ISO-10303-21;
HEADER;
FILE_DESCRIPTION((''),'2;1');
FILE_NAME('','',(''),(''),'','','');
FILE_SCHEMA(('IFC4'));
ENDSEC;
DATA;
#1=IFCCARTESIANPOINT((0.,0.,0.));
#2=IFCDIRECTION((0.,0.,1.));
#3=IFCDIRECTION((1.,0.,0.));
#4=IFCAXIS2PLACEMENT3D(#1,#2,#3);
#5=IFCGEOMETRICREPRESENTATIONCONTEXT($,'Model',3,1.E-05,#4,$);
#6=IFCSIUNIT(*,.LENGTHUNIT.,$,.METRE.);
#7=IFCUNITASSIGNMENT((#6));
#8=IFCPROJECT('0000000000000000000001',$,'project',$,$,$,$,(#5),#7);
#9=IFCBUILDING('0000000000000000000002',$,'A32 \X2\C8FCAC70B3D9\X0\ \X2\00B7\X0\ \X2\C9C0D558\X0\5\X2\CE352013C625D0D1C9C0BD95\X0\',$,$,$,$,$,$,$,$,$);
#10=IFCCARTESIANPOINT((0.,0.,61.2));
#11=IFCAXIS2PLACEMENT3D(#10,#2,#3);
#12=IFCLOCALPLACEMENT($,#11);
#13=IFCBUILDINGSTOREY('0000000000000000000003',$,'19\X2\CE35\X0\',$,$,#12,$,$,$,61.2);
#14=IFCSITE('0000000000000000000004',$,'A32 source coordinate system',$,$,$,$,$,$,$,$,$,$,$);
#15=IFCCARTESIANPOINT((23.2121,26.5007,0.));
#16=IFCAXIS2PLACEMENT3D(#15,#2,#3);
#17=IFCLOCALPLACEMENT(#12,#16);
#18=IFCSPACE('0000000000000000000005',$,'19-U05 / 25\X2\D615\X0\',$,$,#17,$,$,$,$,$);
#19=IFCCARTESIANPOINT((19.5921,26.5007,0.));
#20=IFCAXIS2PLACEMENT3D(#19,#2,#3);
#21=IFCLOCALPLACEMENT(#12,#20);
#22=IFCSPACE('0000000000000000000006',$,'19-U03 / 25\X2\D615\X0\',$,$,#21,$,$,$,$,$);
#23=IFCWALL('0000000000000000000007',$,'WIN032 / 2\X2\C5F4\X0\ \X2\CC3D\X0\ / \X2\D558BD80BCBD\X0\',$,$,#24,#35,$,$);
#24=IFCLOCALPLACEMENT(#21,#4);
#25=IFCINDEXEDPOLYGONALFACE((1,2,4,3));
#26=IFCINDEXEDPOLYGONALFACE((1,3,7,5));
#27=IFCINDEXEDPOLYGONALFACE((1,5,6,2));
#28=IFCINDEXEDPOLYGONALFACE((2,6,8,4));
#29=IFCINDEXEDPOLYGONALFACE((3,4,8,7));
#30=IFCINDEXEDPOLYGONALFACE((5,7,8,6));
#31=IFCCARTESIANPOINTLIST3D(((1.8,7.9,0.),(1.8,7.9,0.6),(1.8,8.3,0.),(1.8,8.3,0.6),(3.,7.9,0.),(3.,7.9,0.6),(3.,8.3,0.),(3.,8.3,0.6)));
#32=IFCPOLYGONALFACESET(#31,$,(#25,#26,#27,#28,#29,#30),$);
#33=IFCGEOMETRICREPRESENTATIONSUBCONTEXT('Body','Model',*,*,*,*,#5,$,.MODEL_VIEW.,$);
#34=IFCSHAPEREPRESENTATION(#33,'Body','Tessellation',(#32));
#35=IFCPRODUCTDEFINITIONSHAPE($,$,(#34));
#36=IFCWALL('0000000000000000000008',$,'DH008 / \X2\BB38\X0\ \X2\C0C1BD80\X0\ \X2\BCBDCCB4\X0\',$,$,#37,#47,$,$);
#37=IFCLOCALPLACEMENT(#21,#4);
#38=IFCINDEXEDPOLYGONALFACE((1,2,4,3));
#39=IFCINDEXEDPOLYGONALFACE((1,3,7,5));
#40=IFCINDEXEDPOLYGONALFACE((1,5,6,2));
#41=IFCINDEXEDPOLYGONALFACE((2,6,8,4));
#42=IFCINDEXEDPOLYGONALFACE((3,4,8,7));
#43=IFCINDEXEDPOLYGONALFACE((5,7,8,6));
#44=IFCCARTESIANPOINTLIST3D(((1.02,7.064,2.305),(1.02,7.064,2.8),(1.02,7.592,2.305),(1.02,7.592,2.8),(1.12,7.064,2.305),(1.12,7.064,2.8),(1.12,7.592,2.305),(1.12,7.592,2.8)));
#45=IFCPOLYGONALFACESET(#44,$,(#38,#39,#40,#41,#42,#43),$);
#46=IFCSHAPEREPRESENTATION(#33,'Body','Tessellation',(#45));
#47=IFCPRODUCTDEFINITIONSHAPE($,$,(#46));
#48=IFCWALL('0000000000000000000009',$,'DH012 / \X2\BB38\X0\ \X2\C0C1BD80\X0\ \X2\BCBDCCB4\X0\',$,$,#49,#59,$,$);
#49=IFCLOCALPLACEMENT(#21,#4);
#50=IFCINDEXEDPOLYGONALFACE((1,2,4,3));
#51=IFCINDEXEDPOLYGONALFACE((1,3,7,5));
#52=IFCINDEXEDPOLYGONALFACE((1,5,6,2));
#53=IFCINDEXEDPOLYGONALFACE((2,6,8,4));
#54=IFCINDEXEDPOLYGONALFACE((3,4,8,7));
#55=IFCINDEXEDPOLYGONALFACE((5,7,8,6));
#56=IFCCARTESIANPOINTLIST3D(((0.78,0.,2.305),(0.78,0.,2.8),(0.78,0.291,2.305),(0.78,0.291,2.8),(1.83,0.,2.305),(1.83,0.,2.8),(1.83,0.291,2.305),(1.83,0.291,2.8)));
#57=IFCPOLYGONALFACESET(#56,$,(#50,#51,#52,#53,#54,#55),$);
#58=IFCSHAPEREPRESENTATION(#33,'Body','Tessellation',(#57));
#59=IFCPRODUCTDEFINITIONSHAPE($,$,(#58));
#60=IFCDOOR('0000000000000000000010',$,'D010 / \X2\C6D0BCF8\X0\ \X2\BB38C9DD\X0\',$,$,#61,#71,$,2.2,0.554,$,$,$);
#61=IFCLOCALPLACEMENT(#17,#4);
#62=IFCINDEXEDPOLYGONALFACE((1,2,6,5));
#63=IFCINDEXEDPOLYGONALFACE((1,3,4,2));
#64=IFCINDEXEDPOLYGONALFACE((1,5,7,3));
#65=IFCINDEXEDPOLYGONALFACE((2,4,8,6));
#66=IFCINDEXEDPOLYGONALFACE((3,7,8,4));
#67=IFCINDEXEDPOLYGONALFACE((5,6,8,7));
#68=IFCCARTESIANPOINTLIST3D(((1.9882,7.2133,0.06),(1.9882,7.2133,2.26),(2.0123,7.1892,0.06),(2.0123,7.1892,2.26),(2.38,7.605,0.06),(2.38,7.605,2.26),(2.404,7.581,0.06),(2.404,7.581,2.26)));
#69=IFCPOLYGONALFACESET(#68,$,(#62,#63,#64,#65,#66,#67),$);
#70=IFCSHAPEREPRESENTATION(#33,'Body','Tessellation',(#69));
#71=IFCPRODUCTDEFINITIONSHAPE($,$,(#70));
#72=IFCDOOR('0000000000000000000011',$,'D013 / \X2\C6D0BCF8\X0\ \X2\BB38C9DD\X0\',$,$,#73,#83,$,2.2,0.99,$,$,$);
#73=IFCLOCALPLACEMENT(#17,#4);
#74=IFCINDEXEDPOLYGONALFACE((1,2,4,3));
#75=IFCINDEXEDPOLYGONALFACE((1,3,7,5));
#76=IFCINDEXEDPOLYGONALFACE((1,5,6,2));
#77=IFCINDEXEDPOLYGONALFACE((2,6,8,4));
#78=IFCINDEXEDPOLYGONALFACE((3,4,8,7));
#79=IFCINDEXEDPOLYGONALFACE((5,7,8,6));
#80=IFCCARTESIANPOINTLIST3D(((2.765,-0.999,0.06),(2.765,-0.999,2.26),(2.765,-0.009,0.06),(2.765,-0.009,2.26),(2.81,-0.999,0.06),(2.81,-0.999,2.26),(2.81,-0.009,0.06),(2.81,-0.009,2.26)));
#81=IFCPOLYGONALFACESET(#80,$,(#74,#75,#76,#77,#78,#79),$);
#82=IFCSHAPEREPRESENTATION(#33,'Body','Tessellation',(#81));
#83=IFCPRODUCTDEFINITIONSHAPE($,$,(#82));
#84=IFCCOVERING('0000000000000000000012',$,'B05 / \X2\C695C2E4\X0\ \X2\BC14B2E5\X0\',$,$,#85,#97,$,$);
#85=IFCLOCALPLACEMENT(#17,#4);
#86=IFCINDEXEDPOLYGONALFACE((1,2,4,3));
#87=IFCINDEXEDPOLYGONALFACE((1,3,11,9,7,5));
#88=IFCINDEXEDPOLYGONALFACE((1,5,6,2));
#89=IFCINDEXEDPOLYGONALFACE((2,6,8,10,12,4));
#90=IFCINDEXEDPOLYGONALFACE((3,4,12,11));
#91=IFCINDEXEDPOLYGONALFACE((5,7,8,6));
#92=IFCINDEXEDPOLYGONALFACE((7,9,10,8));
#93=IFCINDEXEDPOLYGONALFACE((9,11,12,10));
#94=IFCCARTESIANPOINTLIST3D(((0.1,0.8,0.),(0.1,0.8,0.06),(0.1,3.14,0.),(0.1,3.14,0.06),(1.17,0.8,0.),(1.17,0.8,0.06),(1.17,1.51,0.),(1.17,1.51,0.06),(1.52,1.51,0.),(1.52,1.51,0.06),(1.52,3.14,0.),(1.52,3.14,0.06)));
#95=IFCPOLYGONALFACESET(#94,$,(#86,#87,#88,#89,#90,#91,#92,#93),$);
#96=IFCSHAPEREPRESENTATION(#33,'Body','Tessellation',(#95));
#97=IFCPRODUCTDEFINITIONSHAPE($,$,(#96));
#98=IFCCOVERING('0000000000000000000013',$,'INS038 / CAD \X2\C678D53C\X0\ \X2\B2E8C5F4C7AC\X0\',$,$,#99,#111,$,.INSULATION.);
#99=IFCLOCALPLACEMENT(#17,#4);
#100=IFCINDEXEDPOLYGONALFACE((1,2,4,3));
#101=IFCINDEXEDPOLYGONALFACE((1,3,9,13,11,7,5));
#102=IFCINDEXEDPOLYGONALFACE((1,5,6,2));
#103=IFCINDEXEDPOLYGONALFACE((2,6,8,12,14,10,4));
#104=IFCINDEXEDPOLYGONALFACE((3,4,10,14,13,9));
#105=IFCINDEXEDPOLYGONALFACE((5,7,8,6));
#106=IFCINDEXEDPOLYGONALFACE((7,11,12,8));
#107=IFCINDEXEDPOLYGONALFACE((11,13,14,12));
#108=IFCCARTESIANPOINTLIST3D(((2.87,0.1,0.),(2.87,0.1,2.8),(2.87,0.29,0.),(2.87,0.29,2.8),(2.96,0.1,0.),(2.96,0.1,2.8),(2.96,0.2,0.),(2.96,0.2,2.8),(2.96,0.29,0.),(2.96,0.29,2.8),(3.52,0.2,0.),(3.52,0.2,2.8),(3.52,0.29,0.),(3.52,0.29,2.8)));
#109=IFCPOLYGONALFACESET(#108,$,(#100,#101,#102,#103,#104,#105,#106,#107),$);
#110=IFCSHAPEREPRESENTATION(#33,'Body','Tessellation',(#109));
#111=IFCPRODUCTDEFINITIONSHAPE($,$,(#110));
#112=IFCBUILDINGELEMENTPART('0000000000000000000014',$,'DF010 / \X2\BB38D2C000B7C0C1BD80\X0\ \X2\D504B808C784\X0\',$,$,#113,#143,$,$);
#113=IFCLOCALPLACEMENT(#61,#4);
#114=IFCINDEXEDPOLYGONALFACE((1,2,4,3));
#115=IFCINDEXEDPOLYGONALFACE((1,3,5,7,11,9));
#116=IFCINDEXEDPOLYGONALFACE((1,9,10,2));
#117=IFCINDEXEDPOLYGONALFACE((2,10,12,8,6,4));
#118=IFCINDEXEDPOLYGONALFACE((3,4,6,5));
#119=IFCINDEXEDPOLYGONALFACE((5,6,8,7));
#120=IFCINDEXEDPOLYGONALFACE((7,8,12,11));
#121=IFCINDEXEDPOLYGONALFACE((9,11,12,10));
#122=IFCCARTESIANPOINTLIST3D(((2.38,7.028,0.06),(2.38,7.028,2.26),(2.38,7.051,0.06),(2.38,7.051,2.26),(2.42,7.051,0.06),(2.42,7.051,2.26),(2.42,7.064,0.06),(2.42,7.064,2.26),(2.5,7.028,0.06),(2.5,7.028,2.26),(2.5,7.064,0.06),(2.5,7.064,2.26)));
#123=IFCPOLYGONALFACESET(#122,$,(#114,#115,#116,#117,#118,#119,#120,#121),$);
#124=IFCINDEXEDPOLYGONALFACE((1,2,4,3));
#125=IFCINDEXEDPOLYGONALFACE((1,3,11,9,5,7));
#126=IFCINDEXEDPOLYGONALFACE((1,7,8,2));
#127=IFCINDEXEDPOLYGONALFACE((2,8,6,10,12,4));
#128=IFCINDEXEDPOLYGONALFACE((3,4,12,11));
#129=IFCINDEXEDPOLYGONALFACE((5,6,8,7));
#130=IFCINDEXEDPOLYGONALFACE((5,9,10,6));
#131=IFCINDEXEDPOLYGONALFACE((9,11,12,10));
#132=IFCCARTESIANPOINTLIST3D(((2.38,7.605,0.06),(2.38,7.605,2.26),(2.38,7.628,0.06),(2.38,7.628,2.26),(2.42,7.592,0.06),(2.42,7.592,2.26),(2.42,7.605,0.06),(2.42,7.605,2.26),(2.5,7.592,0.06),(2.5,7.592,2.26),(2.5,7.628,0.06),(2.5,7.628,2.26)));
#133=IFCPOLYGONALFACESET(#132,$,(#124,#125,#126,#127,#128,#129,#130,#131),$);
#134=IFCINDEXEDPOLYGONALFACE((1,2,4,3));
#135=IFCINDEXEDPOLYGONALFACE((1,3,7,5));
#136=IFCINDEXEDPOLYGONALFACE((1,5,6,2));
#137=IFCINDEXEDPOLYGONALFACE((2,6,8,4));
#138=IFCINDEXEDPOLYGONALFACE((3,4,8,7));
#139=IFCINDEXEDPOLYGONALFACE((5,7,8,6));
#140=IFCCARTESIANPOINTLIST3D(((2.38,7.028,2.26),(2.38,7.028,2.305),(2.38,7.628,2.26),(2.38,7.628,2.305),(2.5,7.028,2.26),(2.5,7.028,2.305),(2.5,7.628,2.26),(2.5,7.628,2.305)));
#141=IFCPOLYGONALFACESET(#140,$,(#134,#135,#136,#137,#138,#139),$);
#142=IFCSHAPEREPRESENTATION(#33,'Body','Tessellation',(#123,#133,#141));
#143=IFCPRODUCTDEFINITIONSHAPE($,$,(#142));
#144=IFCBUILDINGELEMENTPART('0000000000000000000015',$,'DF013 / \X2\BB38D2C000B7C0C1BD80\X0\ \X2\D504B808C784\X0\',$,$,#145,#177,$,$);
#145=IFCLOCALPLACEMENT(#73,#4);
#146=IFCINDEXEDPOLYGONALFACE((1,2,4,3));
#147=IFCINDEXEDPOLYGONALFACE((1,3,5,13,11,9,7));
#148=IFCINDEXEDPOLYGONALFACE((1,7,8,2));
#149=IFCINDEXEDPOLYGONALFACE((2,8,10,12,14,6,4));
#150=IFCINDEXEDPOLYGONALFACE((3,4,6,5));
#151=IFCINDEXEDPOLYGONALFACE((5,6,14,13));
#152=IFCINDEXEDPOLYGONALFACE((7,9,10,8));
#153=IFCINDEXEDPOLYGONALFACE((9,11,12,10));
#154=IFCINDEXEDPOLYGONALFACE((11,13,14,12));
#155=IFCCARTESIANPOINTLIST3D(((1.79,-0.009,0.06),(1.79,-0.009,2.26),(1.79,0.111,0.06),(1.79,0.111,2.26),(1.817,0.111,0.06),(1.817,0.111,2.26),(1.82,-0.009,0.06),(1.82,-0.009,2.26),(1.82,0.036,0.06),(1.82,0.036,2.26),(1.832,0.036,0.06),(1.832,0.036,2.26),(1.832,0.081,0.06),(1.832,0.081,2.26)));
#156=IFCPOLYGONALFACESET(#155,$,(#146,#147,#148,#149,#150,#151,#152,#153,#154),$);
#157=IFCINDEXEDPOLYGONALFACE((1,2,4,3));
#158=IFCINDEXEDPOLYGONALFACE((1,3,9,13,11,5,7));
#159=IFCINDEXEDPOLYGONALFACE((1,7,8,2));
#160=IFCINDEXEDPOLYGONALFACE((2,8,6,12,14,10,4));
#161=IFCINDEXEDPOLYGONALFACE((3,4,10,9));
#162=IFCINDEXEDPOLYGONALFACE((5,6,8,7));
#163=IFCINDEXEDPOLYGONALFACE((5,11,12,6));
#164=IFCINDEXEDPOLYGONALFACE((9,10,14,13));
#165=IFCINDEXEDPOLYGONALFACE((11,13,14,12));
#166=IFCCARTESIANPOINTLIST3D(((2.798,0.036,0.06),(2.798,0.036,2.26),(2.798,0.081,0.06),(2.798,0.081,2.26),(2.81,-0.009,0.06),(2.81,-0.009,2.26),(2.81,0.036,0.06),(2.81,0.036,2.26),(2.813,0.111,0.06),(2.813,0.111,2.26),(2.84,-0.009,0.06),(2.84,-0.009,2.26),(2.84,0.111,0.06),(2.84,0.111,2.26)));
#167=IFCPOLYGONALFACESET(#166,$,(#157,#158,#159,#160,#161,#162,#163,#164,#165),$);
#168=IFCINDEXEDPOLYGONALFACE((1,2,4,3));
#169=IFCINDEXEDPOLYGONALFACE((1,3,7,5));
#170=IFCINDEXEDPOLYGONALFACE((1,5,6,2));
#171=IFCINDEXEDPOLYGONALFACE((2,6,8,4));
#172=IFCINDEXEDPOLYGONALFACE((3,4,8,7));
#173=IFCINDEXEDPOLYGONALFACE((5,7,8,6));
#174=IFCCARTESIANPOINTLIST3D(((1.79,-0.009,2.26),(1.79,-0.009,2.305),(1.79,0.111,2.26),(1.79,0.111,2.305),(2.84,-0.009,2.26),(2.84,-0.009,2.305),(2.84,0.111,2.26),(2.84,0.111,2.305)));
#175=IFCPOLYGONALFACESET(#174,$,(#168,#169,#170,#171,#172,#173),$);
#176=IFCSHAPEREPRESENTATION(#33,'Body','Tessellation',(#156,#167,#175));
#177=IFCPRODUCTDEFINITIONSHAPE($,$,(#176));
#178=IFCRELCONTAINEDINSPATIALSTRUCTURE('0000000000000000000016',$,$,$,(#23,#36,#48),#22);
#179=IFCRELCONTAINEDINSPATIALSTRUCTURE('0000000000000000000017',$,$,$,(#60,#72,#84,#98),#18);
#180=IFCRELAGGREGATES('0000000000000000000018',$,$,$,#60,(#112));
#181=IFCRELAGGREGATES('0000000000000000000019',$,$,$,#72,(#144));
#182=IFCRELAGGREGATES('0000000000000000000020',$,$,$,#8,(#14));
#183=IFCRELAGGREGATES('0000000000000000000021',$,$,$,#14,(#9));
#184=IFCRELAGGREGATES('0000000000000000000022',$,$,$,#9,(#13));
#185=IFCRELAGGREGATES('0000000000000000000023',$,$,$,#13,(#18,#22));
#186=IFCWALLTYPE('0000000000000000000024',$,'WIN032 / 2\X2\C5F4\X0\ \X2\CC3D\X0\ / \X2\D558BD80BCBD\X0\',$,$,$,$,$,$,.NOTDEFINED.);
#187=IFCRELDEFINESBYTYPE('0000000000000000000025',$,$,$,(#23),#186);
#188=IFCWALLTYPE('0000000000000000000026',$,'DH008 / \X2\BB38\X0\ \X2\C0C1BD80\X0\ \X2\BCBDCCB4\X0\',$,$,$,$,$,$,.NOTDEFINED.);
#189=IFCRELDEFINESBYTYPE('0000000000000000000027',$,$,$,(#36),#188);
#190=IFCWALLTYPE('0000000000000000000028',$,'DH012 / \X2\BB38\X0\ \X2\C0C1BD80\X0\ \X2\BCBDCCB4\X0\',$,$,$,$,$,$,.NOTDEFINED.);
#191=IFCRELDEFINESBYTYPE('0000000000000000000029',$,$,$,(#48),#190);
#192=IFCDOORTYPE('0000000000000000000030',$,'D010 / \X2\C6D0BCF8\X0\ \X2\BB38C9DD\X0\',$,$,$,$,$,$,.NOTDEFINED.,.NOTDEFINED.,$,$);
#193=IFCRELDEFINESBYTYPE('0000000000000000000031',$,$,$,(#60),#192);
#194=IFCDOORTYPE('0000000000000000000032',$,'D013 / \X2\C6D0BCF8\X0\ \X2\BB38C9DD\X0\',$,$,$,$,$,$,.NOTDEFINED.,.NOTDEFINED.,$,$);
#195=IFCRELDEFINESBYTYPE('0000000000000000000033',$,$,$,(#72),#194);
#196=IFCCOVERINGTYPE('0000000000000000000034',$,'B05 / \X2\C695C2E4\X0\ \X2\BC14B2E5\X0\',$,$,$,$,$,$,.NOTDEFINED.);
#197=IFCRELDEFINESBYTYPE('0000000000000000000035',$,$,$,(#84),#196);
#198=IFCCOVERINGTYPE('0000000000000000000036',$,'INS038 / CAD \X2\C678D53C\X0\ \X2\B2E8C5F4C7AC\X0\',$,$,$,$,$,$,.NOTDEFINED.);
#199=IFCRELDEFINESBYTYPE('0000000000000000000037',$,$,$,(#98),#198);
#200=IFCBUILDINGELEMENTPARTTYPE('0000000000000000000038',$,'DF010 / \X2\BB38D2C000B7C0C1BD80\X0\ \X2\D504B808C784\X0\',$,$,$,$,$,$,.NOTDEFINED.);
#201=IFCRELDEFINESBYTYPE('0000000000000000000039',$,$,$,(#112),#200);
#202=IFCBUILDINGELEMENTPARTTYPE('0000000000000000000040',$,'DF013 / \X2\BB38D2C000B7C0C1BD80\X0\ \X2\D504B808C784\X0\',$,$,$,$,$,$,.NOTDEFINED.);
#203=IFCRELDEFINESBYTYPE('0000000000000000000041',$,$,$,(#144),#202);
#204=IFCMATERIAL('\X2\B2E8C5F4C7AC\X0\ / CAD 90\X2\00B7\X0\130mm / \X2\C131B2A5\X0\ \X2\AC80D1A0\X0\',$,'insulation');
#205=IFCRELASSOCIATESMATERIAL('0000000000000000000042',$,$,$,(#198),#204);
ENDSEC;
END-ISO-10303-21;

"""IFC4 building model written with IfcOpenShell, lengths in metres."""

from ifc_helpers import new_model, si_unit, frame, origin, origin_with_axes, place, context, subcontext, project, spatial, polyline, outline, extrude, source, transform, mapped, material, type_object, type_shapes, element, aggregate, save


model = new_model("IFC4")

# Units and contexts
model_context = context("Model", 3, precision=1e-05, world=origin_with_axes())
body_context = subcontext(model_context, "Body", "Model", "MODEL_VIEW")
ifc_project = project(units=[si_unit("LENGTHUNIT", "METRE")], contexts=[model_context])

# Site, building, storey, space
storey_placement = place(None, frame((0.0, 0.0, 61.2), z_axis=(0.0, 0.0, 1.0), x_axis=(1.0, 0.0, 0.0)))
space_1_placement = place(storey_placement, frame((23.2121, 26.5007, 0.0), z_axis=(0.0, 0.0, 1.0), x_axis=(1.0, 0.0, 0.0)))
site = spatial("IfcSite", under=ifc_project, Name="A32 source coordinate system")
building = spatial("IfcBuilding", under=site, Name="A32 주거동 · 지하5층–옥탑지붕")
storey = spatial("IfcBuildingStorey", under=building, at=storey_placement, Name="19층", Elevation=61.2)
space_1 = spatial("IfcSpace", under=storey, at=space_1_placement, Name="19-U05 / 25형")

# Shared definitions
space_2_placement = place(storey_placement, frame((19.5921, 26.5007, 0.0), z_axis=(0.0, 0.0, 1.0), x_axis=(1.0, 0.0, 0.0)))
space_2 = spatial("IfcSpace", under=storey, at=space_2_placement, Name="19-U03 / 25형")

# Walls
wall_type_1 = type_object("IfcWallType", Name="WIN032 / 2열 창 / 하부벽", PredefinedType="NOTDEFINED")
shared_shape_1 = source(origin(), body_context, "Body", "SweptSolid", [
    extrude(outline(polyline([(3.0, 7.9), (1.8, 7.9), (1.8, 8.3), (3.0, 8.3), (3.0, 7.9)])), origin(), (0.0, 0.0, 1.0), 0.6),
])
type_shapes(wall_type_1, [shared_shape_1])
wall_1_placement = place(space_2_placement, origin_with_axes())
element("IfcWall", 1, at=wall_1_placement, inside=space_2, type_object=wall_type_1, Name="WIN032 / 2열 창 / 하부벽", context=body_context, shape_type="MappedRepresentation", body=[
    mapped(shared_shape_1, transform((0.0, 0.0, 0.0), scale=1.0)),
])
wall_type_2 = type_object("IfcWallType", Name="DH008 / 문 상부 벽체", PredefinedType="NOTDEFINED")
shared_shape_2 = source(origin(), body_context, "Body", "SweptSolid", [
    extrude(outline(polyline([(1.12, 7.064), (1.02, 7.064), (1.02, 7.592), (1.12, 7.592), (1.12, 7.064)])), frame((0.0, 0.0, 2.305)), (0.0, 0.0, 1.0), 0.495),
])
type_shapes(wall_type_2, [shared_shape_2])
wall_2_placement = place(space_2_placement, origin_with_axes())
element("IfcWall", 2, at=wall_2_placement, inside=space_2, type_object=wall_type_2, Name="DH008 / 문 상부 벽체", context=body_context, shape_type="MappedRepresentation", body=[
    mapped(shared_shape_2, transform((0.0, 0.0, 0.0), scale=1.0)),
])
wall_type_3 = type_object("IfcWallType", Name="DH012 / 문 상부 벽체", PredefinedType="NOTDEFINED")
shared_shape_3 = source(origin(), body_context, "Body", "SweptSolid", [
    extrude(outline(polyline([(0.78, 0.0), (0.78, 0.291), (1.83, 0.291), (1.83, 0.0), (0.78, 0.0)])), frame((0.0, 0.0, 2.305)), (0.0, 0.0, 1.0), 0.495),
])
type_shapes(wall_type_3, [shared_shape_3])
wall_3_placement = place(space_2_placement, origin_with_axes())
element("IfcWall", 3, at=wall_3_placement, inside=space_2, type_object=wall_type_3, Name="DH012 / 문 상부 벽체", context=body_context, shape_type="MappedRepresentation", body=[
    mapped(shared_shape_3, transform((0.0, 0.0, 0.0), scale=1.0)),
])

# Doors
door_type_1 = type_object("IfcDoorType", Name="D010 / 원본 문짝", OperationType="NOTDEFINED", PredefinedType="NOTDEFINED")
shared_shape_4 = source(origin(), body_context, "Body", "SweptSolid", [
    extrude(outline(polyline([(2.0123, 7.1892), (1.9882, 7.2133), (2.38, 7.605), (2.404, 7.581), (2.0123, 7.1892)])), frame((0.0, 0.0, 0.06)), (0.0, 0.0, 1.0), 2.2),
])
type_shapes(door_type_1, [shared_shape_4])
door_1_placement = place(space_1_placement, origin_with_axes())
door_1 = element("IfcDoor", 4, at=door_1_placement, inside=space_1, type_object=door_type_1, Name="D010 / 원본 문짝", OverallHeight=2.2, OverallWidth=0.554, context=body_context, shape_type="MappedRepresentation", body=[
    mapped(shared_shape_4, transform((0.0, 0.0, 0.0), scale=1.0)),
])
door_type_2 = type_object("IfcDoorType", Name="D013 / 원본 문짝", OperationType="NOTDEFINED", PredefinedType="NOTDEFINED")
shared_shape_5 = source(origin(), body_context, "Body", "SweptSolid", [
    extrude(outline(polyline([(2.81, -0.009), (2.81, -0.999), (2.765, -0.999), (2.765, -0.009), (2.81, -0.009)])), frame((0.0, 0.0, 0.06)), (0.0, 0.0, 1.0), 2.2),
])
type_shapes(door_type_2, [shared_shape_5])
door_2_placement = place(space_1_placement, origin_with_axes())
door_2 = element("IfcDoor", 5, at=door_2_placement, inside=space_1, type_object=door_type_2, Name="D013 / 원본 문짝", OverallHeight=2.2, OverallWidth=0.99, context=body_context, shape_type="MappedRepresentation", body=[
    mapped(shared_shape_5, transform((0.0, 0.0, 0.0), scale=1.0)),
])

# Coverings
covering_type_1 = type_object("IfcCoveringType", Name="B05 / 욕실 바닥", PredefinedType="NOTDEFINED")
shared_shape_6 = source(origin(), body_context, "Body", "SweptSolid", [
    extrude(outline(polyline([(0.1, 3.14), (1.52, 3.14), (1.52, 1.51), (1.17, 1.51), (1.17, 0.8), (0.1, 0.8), (0.1, 3.14)])), origin(), (0.0, 0.0, 1.0), 0.06),
])
type_shapes(covering_type_1, [shared_shape_6])
covering_1_placement = place(space_1_placement, origin_with_axes())
element("IfcCovering", 6, at=covering_1_placement, inside=space_1, type_object=covering_type_1, Name="B05 / 욕실 바닥", context=body_context, shape_type="MappedRepresentation", body=[
    mapped(shared_shape_6, transform((0.0, 0.0, 0.0), scale=1.0)),
])
ifc_material = material(Name="단열재 / CAD 90·130mm / 성능 검토", Category="insulation")
covering_type_2 = type_object("IfcCoveringType", Name="INS038 / CAD 외피 단열재", PredefinedType="NOTDEFINED", material=ifc_material)
shared_shape_7 = source(origin(), body_context, "Body", "SweptSolid", [
    extrude(outline(polyline([(2.96, 0.2), (2.96, 0.1), (2.87, 0.1), (2.87, 0.29), (2.96, 0.29), (3.52, 0.29), (3.52, 0.2), (2.96, 0.2)])), origin(), (0.0, 0.0, 1.0), 2.8),
])
type_shapes(covering_type_2, [shared_shape_7])
covering_2_placement = place(space_1_placement, origin_with_axes())
element("IfcCovering", 7, at=covering_2_placement, inside=space_1, type_object=covering_type_2, Name="INS038 / CAD 외피 단열재", PredefinedType="INSULATION", context=body_context, shape_type="MappedRepresentation", body=[
    mapped(shared_shape_7, transform((0.0, 0.0, 0.0), scale=1.0)),
])

# Building element parts
building_element_part_type_1 = type_object("IfcBuildingElementPartType", Name="DF010 / 문틀·상부 프레임", PredefinedType="NOTDEFINED")
shared_shape_8 = source(origin(), body_context, "Body", "SweptSolid", [
    extrude(outline(polyline([(2.38, 7.028), (2.38, 7.051), (2.42, 7.051), (2.42, 7.064), (2.5, 7.064), (2.5, 7.028), (2.38, 7.028)])), frame((0.0, 0.0, 0.06)), (0.0, 0.0, 1.0), 2.2),
    extrude(outline(polyline([(2.5, 7.592), (2.42, 7.592), (2.42, 7.605), (2.38, 7.605), (2.38, 7.628), (2.5, 7.628), (2.5, 7.592)])), frame((0.0, 0.0, 0.06)), (0.0, 0.0, 1.0), 2.2),
    extrude(outline(polyline([(2.38, 7.028), (2.38, 7.628), (2.5, 7.628), (2.5, 7.028), (2.38, 7.028)])), frame((0.0, 0.0, 2.26)), (0.0, 0.0, 1.0), 0.045),
])
type_shapes(building_element_part_type_1, [shared_shape_8])
building_element_part_1_placement = place(door_1_placement, origin_with_axes())
building_element_part_1 = element("IfcBuildingElementPart", 8, at=building_element_part_1_placement, type_object=building_element_part_type_1, Name="DF010 / 문틀·상부 프레임", context=body_context, shape_type="MappedRepresentation", body=[
    mapped(shared_shape_8, transform((0.0, 0.0, 0.0), scale=1.0)),
])
aggregate(door_1, [building_element_part_1])
building_element_part_type_2 = type_object("IfcBuildingElementPartType", Name="DF013 / 문틀·상부 프레임", PredefinedType="NOTDEFINED")
shared_shape_9 = source(origin(), body_context, "Body", "SweptSolid", [
    extrude(outline(polyline([(1.79, 0.111), (1.817, 0.111), (1.832, 0.081), (1.832, 0.036), (1.82, 0.036), (1.82, -0.009), (1.79, -0.009), (1.79, 0.111)])), frame((0.0, 0.0, 0.06)), (0.0, 0.0, 1.0), 2.2),
    extrude(outline(polyline([(2.81, -0.009), (2.81, 0.036), (2.798, 0.036), (2.798, 0.081), (2.813, 0.111), (2.84, 0.111), (2.84, -0.009), (2.81, -0.009)])), frame((0.0, 0.0, 0.06)), (0.0, 0.0, 1.0), 2.2),
    extrude(outline(polyline([(1.79, -0.009), (1.79, 0.111), (2.84, 0.111), (2.84, -0.009), (1.79, -0.009)])), frame((0.0, 0.0, 2.26)), (0.0, 0.0, 1.0), 0.045),
])
type_shapes(building_element_part_type_2, [shared_shape_9])
building_element_part_2_placement = place(door_2_placement, origin_with_axes())
building_element_part_2 = element("IfcBuildingElementPart", 9, at=building_element_part_2_placement, type_object=building_element_part_type_2, Name="DF013 / 문틀·상부 프레임", context=body_context, shape_type="MappedRepresentation", body=[
    mapped(shared_shape_9, transform((0.0, 0.0, 0.0), scale=1.0)),
])
aggregate(door_2, [building_element_part_2])

save(model, "model.ifc")
